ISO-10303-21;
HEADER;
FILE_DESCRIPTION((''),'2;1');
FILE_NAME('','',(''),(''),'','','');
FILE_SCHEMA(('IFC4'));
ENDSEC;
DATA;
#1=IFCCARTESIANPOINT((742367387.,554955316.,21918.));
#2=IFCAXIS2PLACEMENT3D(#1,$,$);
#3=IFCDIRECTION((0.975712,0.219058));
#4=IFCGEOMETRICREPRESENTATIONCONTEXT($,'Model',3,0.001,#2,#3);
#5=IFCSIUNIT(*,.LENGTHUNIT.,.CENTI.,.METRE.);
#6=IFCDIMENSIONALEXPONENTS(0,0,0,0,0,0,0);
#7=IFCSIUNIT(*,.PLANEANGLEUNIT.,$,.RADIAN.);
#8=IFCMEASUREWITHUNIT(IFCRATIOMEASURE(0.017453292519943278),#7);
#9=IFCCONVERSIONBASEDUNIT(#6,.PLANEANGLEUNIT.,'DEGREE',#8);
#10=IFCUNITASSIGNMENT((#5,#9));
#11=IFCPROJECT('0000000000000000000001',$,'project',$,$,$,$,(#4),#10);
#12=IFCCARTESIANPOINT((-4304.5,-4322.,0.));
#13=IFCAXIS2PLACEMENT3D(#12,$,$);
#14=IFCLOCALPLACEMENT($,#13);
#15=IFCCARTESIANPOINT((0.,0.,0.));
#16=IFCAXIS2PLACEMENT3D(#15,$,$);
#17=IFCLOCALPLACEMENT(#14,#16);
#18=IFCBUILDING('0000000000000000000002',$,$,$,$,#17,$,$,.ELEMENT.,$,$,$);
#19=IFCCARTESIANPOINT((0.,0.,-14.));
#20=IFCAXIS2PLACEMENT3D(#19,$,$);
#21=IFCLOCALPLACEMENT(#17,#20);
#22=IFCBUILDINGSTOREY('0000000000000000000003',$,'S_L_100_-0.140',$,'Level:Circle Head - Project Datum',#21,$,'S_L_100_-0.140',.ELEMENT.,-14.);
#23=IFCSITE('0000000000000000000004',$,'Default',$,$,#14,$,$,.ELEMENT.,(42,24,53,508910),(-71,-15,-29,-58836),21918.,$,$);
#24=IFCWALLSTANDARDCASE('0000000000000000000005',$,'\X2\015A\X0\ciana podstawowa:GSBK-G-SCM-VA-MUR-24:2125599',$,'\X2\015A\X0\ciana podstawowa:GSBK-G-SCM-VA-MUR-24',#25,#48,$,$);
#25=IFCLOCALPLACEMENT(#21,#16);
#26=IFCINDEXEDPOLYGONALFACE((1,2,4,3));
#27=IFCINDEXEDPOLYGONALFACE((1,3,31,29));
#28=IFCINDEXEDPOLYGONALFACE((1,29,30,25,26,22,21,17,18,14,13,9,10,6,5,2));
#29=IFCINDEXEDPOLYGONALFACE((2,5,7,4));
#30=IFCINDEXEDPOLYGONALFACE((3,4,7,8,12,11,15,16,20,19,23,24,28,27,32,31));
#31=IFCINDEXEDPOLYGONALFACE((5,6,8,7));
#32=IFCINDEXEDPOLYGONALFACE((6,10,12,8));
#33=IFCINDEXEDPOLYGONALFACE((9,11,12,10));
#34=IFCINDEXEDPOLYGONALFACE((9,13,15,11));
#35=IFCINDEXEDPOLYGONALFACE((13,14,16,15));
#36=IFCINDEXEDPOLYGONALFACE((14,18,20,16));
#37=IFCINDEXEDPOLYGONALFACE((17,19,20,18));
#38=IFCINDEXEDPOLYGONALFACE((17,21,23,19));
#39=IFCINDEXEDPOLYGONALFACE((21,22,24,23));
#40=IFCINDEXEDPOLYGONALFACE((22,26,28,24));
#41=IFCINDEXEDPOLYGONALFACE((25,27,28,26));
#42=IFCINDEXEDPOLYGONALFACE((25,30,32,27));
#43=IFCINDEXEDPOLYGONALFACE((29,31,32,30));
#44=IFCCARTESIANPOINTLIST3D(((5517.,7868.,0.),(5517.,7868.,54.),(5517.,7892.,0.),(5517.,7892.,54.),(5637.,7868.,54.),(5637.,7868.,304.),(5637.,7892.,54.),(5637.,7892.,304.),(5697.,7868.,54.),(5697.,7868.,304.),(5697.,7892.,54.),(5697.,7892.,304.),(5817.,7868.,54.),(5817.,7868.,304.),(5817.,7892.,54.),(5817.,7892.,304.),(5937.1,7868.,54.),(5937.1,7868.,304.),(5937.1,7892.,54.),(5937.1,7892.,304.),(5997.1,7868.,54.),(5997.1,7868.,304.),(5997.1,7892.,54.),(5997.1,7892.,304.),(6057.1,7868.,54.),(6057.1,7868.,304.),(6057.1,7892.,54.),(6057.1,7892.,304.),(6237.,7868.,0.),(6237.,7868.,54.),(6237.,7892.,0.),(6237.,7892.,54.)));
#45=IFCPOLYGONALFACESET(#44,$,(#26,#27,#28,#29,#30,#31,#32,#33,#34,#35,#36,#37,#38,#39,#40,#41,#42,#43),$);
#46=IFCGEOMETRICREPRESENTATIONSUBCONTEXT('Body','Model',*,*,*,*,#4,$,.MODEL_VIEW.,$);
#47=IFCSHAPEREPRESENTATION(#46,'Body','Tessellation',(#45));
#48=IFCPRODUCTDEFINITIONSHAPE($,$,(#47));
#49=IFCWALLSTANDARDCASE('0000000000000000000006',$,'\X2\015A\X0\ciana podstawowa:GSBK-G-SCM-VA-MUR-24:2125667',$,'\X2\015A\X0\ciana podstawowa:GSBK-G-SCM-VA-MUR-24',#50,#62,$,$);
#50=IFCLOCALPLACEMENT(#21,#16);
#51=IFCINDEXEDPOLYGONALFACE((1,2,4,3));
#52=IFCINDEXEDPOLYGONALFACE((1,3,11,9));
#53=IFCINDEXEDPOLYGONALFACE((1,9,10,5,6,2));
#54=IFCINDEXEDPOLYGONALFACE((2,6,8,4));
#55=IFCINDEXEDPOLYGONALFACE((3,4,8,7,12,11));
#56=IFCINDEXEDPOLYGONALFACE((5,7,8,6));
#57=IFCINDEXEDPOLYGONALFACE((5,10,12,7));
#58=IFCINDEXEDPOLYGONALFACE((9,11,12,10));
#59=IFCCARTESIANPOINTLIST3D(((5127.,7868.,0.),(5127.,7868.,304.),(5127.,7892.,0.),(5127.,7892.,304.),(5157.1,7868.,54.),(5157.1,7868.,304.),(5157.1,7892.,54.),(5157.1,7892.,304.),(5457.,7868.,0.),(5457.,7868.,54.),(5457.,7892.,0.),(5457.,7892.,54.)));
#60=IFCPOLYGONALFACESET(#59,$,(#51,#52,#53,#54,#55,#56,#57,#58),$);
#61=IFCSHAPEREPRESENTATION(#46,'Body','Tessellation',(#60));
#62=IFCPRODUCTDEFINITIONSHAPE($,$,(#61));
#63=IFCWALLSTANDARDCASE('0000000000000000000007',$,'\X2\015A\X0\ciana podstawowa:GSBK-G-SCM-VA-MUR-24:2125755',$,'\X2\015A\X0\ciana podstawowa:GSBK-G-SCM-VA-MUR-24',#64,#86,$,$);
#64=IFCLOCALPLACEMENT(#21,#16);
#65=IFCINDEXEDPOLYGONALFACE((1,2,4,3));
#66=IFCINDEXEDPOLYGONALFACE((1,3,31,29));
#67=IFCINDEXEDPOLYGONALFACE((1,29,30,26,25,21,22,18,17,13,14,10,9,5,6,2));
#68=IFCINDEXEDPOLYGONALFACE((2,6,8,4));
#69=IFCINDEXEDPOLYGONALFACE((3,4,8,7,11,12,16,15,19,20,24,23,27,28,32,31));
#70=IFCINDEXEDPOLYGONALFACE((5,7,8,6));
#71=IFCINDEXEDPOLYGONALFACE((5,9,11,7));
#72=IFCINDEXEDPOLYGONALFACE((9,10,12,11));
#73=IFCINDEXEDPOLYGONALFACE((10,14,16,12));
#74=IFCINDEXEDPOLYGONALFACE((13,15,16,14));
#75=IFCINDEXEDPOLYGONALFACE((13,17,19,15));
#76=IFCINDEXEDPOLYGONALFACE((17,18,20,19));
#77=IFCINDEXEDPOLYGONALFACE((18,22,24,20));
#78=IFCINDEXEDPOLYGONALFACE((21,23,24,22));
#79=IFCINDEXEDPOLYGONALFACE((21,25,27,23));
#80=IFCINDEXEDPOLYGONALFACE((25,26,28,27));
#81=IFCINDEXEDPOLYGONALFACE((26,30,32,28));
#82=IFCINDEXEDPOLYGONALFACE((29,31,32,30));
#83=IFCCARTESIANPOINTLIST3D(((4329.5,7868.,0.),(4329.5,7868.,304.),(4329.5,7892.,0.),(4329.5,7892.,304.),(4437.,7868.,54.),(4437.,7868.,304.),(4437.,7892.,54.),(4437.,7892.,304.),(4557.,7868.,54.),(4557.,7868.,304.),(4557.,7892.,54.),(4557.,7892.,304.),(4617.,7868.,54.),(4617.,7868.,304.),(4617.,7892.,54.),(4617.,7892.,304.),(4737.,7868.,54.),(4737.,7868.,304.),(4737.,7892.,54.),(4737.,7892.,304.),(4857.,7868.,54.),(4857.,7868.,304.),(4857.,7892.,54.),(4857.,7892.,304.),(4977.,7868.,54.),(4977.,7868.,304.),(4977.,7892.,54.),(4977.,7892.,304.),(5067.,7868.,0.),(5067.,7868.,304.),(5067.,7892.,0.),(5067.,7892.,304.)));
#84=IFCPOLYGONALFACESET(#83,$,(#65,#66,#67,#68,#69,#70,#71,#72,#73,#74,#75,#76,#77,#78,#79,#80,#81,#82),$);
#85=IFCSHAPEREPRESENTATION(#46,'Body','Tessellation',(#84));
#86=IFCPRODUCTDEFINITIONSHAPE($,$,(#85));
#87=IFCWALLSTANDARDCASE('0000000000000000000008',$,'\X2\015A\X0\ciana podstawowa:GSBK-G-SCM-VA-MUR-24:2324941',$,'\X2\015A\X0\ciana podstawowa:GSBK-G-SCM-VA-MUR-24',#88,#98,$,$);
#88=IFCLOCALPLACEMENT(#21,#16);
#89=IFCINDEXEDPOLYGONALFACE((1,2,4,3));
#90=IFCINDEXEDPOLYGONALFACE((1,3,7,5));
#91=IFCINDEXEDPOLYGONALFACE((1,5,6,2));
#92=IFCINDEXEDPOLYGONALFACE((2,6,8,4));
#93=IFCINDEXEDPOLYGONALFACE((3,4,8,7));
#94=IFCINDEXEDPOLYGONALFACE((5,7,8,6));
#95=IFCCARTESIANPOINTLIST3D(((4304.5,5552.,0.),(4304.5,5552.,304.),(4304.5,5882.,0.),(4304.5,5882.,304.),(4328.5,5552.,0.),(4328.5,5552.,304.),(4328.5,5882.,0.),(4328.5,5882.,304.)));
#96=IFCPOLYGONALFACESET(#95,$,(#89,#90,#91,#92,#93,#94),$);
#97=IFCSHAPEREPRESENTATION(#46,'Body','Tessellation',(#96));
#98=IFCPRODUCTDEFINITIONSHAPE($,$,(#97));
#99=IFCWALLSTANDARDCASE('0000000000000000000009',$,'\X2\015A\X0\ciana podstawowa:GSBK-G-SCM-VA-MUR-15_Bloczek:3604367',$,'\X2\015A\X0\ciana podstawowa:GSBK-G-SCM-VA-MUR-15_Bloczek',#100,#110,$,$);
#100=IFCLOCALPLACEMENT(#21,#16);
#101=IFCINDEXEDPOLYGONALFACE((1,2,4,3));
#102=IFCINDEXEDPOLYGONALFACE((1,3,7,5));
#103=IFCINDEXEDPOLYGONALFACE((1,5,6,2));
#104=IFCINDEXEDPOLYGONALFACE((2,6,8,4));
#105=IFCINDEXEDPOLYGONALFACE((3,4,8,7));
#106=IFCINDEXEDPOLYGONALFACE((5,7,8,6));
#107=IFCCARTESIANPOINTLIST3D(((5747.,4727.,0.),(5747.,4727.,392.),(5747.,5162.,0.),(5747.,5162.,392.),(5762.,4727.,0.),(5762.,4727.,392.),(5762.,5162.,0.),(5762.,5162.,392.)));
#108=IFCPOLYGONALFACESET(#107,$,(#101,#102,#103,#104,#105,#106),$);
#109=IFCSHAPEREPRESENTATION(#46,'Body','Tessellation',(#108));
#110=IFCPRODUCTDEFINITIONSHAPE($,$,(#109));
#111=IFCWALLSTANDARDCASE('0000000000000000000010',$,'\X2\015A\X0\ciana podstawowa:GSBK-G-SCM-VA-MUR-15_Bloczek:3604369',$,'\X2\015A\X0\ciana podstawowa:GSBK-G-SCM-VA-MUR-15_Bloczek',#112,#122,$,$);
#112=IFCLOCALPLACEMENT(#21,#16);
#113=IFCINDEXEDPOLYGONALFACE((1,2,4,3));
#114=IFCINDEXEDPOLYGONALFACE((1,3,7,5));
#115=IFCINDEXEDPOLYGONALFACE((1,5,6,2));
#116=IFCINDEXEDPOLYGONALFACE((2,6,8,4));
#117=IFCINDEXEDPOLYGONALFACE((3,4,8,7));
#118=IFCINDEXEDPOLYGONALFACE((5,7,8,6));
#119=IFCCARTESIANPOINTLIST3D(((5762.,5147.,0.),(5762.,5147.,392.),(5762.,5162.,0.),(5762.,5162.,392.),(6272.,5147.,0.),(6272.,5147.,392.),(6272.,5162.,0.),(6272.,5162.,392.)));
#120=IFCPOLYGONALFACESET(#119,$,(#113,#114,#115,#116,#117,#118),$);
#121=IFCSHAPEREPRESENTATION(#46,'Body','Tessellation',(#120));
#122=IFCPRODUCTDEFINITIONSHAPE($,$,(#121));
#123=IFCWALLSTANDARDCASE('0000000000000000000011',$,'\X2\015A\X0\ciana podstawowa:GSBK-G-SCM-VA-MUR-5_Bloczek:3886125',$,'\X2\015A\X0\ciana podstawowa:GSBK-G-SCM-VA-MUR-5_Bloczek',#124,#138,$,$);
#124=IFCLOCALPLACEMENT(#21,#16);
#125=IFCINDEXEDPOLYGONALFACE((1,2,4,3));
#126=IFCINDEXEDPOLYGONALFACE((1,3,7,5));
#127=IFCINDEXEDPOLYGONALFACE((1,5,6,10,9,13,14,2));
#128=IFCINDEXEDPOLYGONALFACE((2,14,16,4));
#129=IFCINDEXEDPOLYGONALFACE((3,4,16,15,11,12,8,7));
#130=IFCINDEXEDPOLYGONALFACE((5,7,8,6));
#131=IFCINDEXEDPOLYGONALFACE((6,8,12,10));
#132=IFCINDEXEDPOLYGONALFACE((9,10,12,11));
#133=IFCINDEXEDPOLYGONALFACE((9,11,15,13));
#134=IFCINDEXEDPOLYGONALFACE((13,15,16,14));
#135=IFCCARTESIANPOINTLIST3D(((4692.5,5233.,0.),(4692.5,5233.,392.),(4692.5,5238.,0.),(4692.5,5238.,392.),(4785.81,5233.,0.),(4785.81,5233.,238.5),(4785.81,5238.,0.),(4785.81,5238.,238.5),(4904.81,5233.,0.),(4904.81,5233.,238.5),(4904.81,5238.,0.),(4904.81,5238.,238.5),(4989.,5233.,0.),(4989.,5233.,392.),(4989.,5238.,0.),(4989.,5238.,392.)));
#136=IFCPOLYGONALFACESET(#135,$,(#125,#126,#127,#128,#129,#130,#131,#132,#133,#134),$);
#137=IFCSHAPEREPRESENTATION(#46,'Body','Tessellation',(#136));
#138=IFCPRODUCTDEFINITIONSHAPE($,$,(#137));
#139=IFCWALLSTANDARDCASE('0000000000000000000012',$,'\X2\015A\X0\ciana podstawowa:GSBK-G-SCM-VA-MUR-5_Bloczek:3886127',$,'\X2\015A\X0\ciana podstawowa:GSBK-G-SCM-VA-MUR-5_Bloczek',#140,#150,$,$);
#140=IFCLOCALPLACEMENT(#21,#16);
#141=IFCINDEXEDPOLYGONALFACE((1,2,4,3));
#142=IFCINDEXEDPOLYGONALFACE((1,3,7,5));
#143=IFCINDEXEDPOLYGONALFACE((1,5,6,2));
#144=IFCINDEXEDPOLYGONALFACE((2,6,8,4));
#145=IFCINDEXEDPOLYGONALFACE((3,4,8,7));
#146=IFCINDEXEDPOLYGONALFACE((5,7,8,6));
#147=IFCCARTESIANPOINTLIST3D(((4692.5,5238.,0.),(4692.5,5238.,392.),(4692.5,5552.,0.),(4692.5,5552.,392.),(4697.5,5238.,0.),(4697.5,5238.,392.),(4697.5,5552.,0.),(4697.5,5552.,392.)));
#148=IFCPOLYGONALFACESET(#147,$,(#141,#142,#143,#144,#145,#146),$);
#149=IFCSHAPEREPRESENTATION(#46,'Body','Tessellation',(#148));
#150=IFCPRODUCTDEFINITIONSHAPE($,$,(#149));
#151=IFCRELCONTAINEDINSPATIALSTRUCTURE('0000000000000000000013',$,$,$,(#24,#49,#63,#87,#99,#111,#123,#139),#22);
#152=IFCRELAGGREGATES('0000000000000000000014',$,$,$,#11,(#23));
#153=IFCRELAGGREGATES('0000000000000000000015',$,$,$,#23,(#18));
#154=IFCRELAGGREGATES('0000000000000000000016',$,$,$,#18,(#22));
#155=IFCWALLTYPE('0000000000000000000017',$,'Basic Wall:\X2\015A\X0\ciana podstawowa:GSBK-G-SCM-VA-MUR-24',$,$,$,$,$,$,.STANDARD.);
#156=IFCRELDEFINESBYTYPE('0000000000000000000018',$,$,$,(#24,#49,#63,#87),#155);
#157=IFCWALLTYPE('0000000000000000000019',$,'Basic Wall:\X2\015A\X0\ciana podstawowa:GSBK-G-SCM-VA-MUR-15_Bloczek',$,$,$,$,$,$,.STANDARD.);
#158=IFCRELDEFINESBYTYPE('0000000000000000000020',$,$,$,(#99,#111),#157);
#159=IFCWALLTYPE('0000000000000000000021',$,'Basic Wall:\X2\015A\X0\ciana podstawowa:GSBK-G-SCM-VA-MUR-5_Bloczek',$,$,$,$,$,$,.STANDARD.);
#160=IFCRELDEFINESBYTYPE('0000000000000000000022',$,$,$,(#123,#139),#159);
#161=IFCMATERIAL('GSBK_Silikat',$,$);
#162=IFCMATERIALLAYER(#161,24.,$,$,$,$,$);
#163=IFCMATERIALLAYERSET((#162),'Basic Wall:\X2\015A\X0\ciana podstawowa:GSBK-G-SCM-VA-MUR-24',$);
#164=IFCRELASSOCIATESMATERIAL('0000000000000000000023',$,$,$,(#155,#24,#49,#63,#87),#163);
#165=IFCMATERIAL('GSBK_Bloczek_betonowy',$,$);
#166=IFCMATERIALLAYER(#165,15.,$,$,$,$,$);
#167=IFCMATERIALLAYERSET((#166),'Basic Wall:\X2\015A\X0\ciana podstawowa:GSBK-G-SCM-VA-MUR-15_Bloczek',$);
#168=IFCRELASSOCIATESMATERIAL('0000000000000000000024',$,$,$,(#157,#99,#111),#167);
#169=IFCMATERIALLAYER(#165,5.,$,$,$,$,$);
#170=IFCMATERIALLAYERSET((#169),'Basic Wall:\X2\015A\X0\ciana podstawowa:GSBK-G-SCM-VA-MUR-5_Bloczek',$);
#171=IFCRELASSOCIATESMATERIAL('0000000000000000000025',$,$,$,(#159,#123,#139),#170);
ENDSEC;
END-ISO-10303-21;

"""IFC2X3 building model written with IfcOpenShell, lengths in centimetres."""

from ifc_helpers import new_model, entity, si_unit, converted_unit, direction, frame, frame_2d, origin, origin_2d_with_axis, place, context, subcontext, project, spatial, rectangle, extrude, material, layer, layer_set, layer_usage, type_object, element, save


model = new_model("IFC2X3")

# Units and contexts
model_context = context("Model", 3, precision=0.001, world=frame((742367387.0, 554955316.0, 21918.0)), true_north=direction((0.975712, 0.219058)))
body_context = subcontext(model_context, "Body", "Model", "MODEL_VIEW")
ifc_project = project(units=[si_unit("LENGTHUNIT", "METRE", prefix="CENTI"), converted_unit("PLANEANGLEUNIT", "DEGREE", entity("IfcRatioMeasure", 0.017453292519943278), si_unit("PLANEANGLEUNIT", "RADIAN"), dimensions=[0, 0, 0, 0, 0, 0, 0])], contexts=[model_context])

# Site, building, storey
site_placement = place(None, frame((-4304.5, -4322.0, 0.0)))
site = spatial("IfcSite", under=ifc_project, at=site_placement, Name="Default", CompositionType="ELEMENT", RefLatitude=(42, 24, 53, 508910), RefLongitude=(-71, -15, -29, -58836), RefElevation=21918.0)
building_placement = place(site_placement, origin())
building = spatial("IfcBuilding", under=site, at=building_placement, CompositionType="ELEMENT")
storey_placement = place(building_placement, frame((0.0, 0.0, -14.0)))
storey = spatial("IfcBuildingStorey", under=building, at=storey_placement, Name="S_L_100_-0.140", ObjectType="Level:Circle Head - Project Datum", LongName="S_L_100_-0.140", CompositionType="ELEMENT", Elevation=-14.0)

# Wall, openings
ifc_material_1 = material(Name="GSBK_Silikat")
ifc_layer_1 = layer(ifc_material_1, 24.0)
ifc_layer_set_1 = layer_set([ifc_layer_1], Name="Basic Wall:Ściana podstawowa:GSBK-G-SCM-VA-MUR-24")
ifc_layer_usage_1 = layer_usage(ifc_layer_set_1, "AXIS2", "NEGATIVE", 12.0)
wall_type_1 = type_object("IfcWallType", Name="Basic Wall:Ściana podstawowa:GSBK-G-SCM-VA-MUR-24", PredefinedType="STANDARD", material=ifc_layer_set_1)
wall_1_placement = place(storey_placement, frame((6237.0, 7880.0, 0.0), z_axis=(0.0, 0.0, 1.0), x_axis=(-1.0, 0.0, 0.0)))
wall_1 = element("IfcWallStandardCase", 1, at=wall_1_placement, inside=storey, type_object=wall_type_1, material=ifc_layer_usage_1, Name="Ściana podstawowa:GSBK-G-SCM-VA-MUR-24:2125599", ObjectType="Ściana podstawowa:GSBK-G-SCM-VA-MUR-24", context=body_context, shape_type="SweptSolid", body=[
    extrude(rectangle(XDim=720.0, YDim=24.0, at=frame_2d((360.0, 0.0), x_axis=(-1.0, 0.0))), origin(), (0.0, 0.0, 1.0), 304.0),
])
opening_1_placement = place(wall_1_placement, frame((540.0, 12.0, 54.0)))
element("IfcOpeningElement", 2, at=opening_1_placement, cuts=wall_1, ObjectType="Opening", context=body_context, shape_type="SweptSolid", body=[
    extrude(rectangle(XDim=250.0, YDim=120.0, at=origin_2d_with_axis()), frame((-60.0, -24.0, 125.0), z_axis=(0.0, 1.0, 0.0), x_axis=(0.0, 0.0, -1.0)), (0.0, 0.0, 1.0), 24.0),
])
opening_2_placement = place(wall_1_placement, frame((720.0, 12.0, 54.0)))
element("IfcOpeningElement", 3, at=opening_2_placement, cuts=wall_1, ObjectType="Opening", context=body_context, shape_type="SweptSolid", body=[
    extrude(rectangle(XDim=250.0, YDim=120.0, at=frame_2d((0.0, 0.0), x_axis=(1.0, 0.0))), frame((-60.0, -24.0, 125.0), z_axis=(0.0, 1.0, 0.0), x_axis=(0.0, 0.0, -1.0)), (0.0, 0.0, 1.0), 24.0),
])
opening_3_placement = place(wall_1_placement, frame((299.9, 12.0, 54.0)))
element("IfcOpeningElement", 4, at=opening_3_placement, cuts=wall_1, ObjectType="Opening", context=body_context, shape_type="SweptSolid", body=[
    extrude(rectangle(XDim=250.0, YDim=60.0, at=origin_2d_with_axis()), frame((-30.0, -24.0, 125.0), z_axis=(0.0, 1.0, 0.0), x_axis=(0.0, 0.0, -1.0)), (0.0, 0.0, 1.0), 24.0),
])
opening_4_placement = place(wall_1_placement, frame((179.9, 12.0, 54.0)))
element("IfcOpeningElement", 5, at=opening_4_placement, cuts=wall_1, ObjectType="Opening", context=body_context, shape_type="SweptSolid", body=[
    extrude(rectangle(XDim=250.0, YDim=180.0, at=frame_2d((0.0, 0.0), x_axis=(1.0, 0.0))), frame((-90.0, -24.0, 125.0), z_axis=(0.0, 1.0, 0.0), x_axis=(0.0, 0.0, -1.0)), (0.0, 0.0, 1.0), 24.0),
])

# Wall, opening
ifc_layer_usage_2 = layer_usage(ifc_layer_set_1, "AXIS2", "NEGATIVE", 12.0)
wall_2_placement = place(storey_placement, frame((5457.0, 7880.0, 0.0), z_axis=(0.0, 0.0, 1.0), x_axis=(-1.0, 0.0, 0.0)))
wall_2 = element("IfcWallStandardCase", 6, at=wall_2_placement, inside=storey, type_object=wall_type_1, material=ifc_layer_usage_2, Name="Ściana podstawowa:GSBK-G-SCM-VA-MUR-24:2125667", ObjectType="Ściana podstawowa:GSBK-G-SCM-VA-MUR-24", context=body_context, shape_type="SweptSolid", body=[
    extrude(rectangle(XDim=330.0, YDim=24.0, at=frame_2d((165.0, 0.0), x_axis=(-1.0, 0.0))), origin(), (0.0, 0.0, 1.0), 304.0),
])
opening_5_placement = place(wall_2_placement, frame((299.9, 12.0, 54.0)))
element("IfcOpeningElement", 7, at=opening_5_placement, cuts=wall_2, ObjectType="Opening", context=body_context, shape_type="SweptSolid", body=[
    extrude(rectangle(XDim=250.0, YDim=300.0, at=frame_2d((0.0, 0.0), x_axis=(1.0, 0.0))), frame((-150.0, -24.0, 125.0), z_axis=(0.0, 1.0, 0.0), x_axis=(0.0, 0.0, -1.0)), (0.0, 0.0, 1.0), 24.0),
])

# Wall, openings
ifc_layer_usage_3 = layer_usage(ifc_layer_set_1, "AXIS2", "NEGATIVE", 12.0)
wall_3_placement = place(storey_placement, frame((5067.0, 7880.0, 0.0), z_axis=(0.0, 0.0, 1.0), x_axis=(-1.0, 0.0, 0.0)))
wall_3 = element("IfcWallStandardCase", 8, at=wall_3_placement, inside=storey, type_object=wall_type_1, material=ifc_layer_usage_3, Name="Ściana podstawowa:GSBK-G-SCM-VA-MUR-24:2125755", ObjectType="Ściana podstawowa:GSBK-G-SCM-VA-MUR-24", context=body_context, shape_type="SweptSolid", body=[
    extrude(rectangle(XDim=737.5, YDim=24.0, at=frame_2d((368.75, 0.0), x_axis=(-1.0, 0.0))), origin(), (0.0, 0.0, 1.0), 304.0),
])
opening_6_placement = place(wall_3_placement, frame((630.0, 12.0, 54.0)))
element("IfcOpeningElement", 9, at=opening_6_placement, cuts=wall_3, ObjectType="Opening", context=body_context, shape_type="SweptSolid", body=[
    extrude(rectangle(XDim=250.0, YDim=120.0, at=origin_2d_with_axis()), frame((-60.0, -24.0, 125.0), z_axis=(0.0, 1.0, 0.0), x_axis=(0.0, 0.0, -1.0)), (0.0, 0.0, 1.0), 24.0),
])
opening_7_placement = place(wall_3_placement, frame((450.0, 12.0, 54.0)))
element("IfcOpeningElement", 10, at=opening_7_placement, cuts=wall_3, ObjectType="Opening", context=body_context, shape_type="SweptSolid", body=[
    extrude(rectangle(XDim=250.0, YDim=120.0, at=frame_2d((0.0, 0.0), x_axis=(1.0, 0.0))), frame((-60.0, -24.0, 125.0), z_axis=(0.0, 1.0, 0.0), x_axis=(0.0, 0.0, -1.0)), (0.0, 0.0, 1.0), 24.0),
])
opening_8_placement = place(wall_3_placement, frame((210.0, 12.0, 54.0)))
element("IfcOpeningElement", 11, at=opening_8_placement, cuts=wall_3, ObjectType="Opening", context=body_context, shape_type="SweptSolid", body=[
    extrude(rectangle(XDim=250.0, YDim=120.0, at=frame_2d((0.0, 0.0), x_axis=(1.0, 0.0))), frame((-60.0, -24.0, 125.0), z_axis=(0.0, 1.0, 0.0), x_axis=(0.0, 0.0, -1.0)), (0.0, 0.0, 1.0), 24.0),
])

# Walls
ifc_layer_usage_4 = layer_usage(ifc_layer_set_1, "AXIS2", "NEGATIVE", 12.0)
wall_4_placement = place(storey_placement, frame((4316.5, 5552.0, 0.0), z_axis=(0.0, 0.0, 1.0), x_axis=(0.0, 1.0, 0.0)))
element("IfcWallStandardCase", 12, at=wall_4_placement, inside=storey, type_object=wall_type_1, material=ifc_layer_usage_4, Name="Ściana podstawowa:GSBK-G-SCM-VA-MUR-24:2324941", ObjectType="Ściana podstawowa:GSBK-G-SCM-VA-MUR-24", context=body_context, shape_type="SweptSolid", body=[
    extrude(rectangle(XDim=330.0, YDim=24.0, at=frame_2d((165.0, 0.0), x_axis=(-1.0, 0.0))), origin(), (0.0, 0.0, 1.0), 304.0),
])
ifc_material_2 = material(Name="GSBK_Bloczek_betonowy")
ifc_layer_2 = layer(ifc_material_2, 15.0)
ifc_layer_set_2 = layer_set([ifc_layer_2], Name="Basic Wall:Ściana podstawowa:GSBK-G-SCM-VA-MUR-15_Bloczek")
ifc_layer_usage_5 = layer_usage(ifc_layer_set_2, "AXIS2", "NEGATIVE", 7.5)
wall_type_2 = type_object("IfcWallType", Name="Basic Wall:Ściana podstawowa:GSBK-G-SCM-VA-MUR-15_Bloczek", PredefinedType="STANDARD", material=ifc_layer_set_2)
wall_5_placement = place(storey_placement, frame((5754.5, 5162.0, 0.0), z_axis=(0.0, 0.0, 1.0), x_axis=(0.0, -1.0, 0.0)))
element("IfcWallStandardCase", 13, at=wall_5_placement, inside=storey, type_object=wall_type_2, material=ifc_layer_usage_5, Name="Ściana podstawowa:GSBK-G-SCM-VA-MUR-15_Bloczek:3604367", ObjectType="Ściana podstawowa:GSBK-G-SCM-VA-MUR-15_Bloczek", context=body_context, shape_type="SweptSolid", body=[
    extrude(rectangle(XDim=435.0, YDim=15.0, at=frame_2d((217.5, 0.0), x_axis=(-1.0, 0.0))), origin(), (0.0, 0.0, 1.0), 392.0),
])
ifc_layer_usage_6 = layer_usage(ifc_layer_set_2, "AXIS2", "NEGATIVE", 7.5)
wall_6_placement = place(storey_placement, frame((5762.0, 5154.5, 0.0)))
element("IfcWallStandardCase", 14, at=wall_6_placement, inside=storey, type_object=wall_type_2, material=ifc_layer_usage_6, Name="Ściana podstawowa:GSBK-G-SCM-VA-MUR-15_Bloczek:3604369", ObjectType="Ściana podstawowa:GSBK-G-SCM-VA-MUR-15_Bloczek", context=body_context, shape_type="SweptSolid", body=[
    extrude(rectangle(XDim=510.0, YDim=15.0, at=frame_2d((255.0, 0.0), x_axis=(-1.0, 0.0))), origin(), (0.0, 0.0, 1.0), 392.0),
])

# Wall, opening
ifc_layer_3 = layer(ifc_material_2, 5.0)
ifc_layer_set_3 = layer_set([ifc_layer_3], Name="Basic Wall:Ściana podstawowa:GSBK-G-SCM-VA-MUR-5_Bloczek")
ifc_layer_usage_7 = layer_usage(ifc_layer_set_3, "AXIS2", "NEGATIVE", 2.5)
wall_type_3 = type_object("IfcWallType", Name="Basic Wall:Ściana podstawowa:GSBK-G-SCM-VA-MUR-5_Bloczek", PredefinedType="STANDARD", material=ifc_layer_set_3)
wall_7_placement = place(storey_placement, frame((4692.5, 5235.5, 0.0)))
wall_7 = element("IfcWallStandardCase", 15, at=wall_7_placement, inside=storey, type_object=wall_type_3, material=ifc_layer_usage_7, Name="Ściana podstawowa:GSBK-G-SCM-VA-MUR-5_Bloczek:3886125", ObjectType="Ściana podstawowa:GSBK-G-SCM-VA-MUR-5_Bloczek", context=body_context, shape_type="SweptSolid", body=[
    extrude(rectangle(XDim=296.5, YDim=5.0, at=frame_2d((148.25, 0.0), x_axis=(1.0, 0.0))), origin(), (0.0, 0.0, 1.0), 392.0),
])
opening_9_placement = place(wall_7_placement, frame((93.31, -2.5, 0.0)))
element("IfcOpeningElement", 16, at=opening_9_placement, cuts=wall_7, ObjectType="Opening", context=body_context, shape_type="SweptSolid", body=[
    extrude(rectangle(XDim=238.5, YDim=119.0, at=frame_2d((0.0, 0.0), x_axis=(1.0, 0.0))), frame((59.5, 0.0, 119.25), z_axis=(0.0, 1.0, 0.0), x_axis=(0.0, 0.0, -1.0)), (0.0, 0.0, 1.0), 5.0),
])

# Wall
ifc_layer_usage_8 = layer_usage(ifc_layer_set_3, "AXIS2", "NEGATIVE", 2.5)
wall_8_placement = place(storey_placement, frame((4695.0, 5552.0, 0.0), z_axis=(0.0, 0.0, 1.0), x_axis=(0.0, -1.0, 0.0)))
element("IfcWallStandardCase", 17, at=wall_8_placement, inside=storey, type_object=wall_type_3, material=ifc_layer_usage_8, Name="Ściana podstawowa:GSBK-G-SCM-VA-MUR-5_Bloczek:3886127", ObjectType="Ściana podstawowa:GSBK-G-SCM-VA-MUR-5_Bloczek", context=body_context, shape_type="SweptSolid", body=[
    extrude(rectangle(XDim=314.0, YDim=5.0, at=frame_2d((157.0, 0.0), x_axis=(-1.0, 0.0))), origin(), (0.0, 0.0, 1.0), 392.0),
])

save(model, "model.ifc")
